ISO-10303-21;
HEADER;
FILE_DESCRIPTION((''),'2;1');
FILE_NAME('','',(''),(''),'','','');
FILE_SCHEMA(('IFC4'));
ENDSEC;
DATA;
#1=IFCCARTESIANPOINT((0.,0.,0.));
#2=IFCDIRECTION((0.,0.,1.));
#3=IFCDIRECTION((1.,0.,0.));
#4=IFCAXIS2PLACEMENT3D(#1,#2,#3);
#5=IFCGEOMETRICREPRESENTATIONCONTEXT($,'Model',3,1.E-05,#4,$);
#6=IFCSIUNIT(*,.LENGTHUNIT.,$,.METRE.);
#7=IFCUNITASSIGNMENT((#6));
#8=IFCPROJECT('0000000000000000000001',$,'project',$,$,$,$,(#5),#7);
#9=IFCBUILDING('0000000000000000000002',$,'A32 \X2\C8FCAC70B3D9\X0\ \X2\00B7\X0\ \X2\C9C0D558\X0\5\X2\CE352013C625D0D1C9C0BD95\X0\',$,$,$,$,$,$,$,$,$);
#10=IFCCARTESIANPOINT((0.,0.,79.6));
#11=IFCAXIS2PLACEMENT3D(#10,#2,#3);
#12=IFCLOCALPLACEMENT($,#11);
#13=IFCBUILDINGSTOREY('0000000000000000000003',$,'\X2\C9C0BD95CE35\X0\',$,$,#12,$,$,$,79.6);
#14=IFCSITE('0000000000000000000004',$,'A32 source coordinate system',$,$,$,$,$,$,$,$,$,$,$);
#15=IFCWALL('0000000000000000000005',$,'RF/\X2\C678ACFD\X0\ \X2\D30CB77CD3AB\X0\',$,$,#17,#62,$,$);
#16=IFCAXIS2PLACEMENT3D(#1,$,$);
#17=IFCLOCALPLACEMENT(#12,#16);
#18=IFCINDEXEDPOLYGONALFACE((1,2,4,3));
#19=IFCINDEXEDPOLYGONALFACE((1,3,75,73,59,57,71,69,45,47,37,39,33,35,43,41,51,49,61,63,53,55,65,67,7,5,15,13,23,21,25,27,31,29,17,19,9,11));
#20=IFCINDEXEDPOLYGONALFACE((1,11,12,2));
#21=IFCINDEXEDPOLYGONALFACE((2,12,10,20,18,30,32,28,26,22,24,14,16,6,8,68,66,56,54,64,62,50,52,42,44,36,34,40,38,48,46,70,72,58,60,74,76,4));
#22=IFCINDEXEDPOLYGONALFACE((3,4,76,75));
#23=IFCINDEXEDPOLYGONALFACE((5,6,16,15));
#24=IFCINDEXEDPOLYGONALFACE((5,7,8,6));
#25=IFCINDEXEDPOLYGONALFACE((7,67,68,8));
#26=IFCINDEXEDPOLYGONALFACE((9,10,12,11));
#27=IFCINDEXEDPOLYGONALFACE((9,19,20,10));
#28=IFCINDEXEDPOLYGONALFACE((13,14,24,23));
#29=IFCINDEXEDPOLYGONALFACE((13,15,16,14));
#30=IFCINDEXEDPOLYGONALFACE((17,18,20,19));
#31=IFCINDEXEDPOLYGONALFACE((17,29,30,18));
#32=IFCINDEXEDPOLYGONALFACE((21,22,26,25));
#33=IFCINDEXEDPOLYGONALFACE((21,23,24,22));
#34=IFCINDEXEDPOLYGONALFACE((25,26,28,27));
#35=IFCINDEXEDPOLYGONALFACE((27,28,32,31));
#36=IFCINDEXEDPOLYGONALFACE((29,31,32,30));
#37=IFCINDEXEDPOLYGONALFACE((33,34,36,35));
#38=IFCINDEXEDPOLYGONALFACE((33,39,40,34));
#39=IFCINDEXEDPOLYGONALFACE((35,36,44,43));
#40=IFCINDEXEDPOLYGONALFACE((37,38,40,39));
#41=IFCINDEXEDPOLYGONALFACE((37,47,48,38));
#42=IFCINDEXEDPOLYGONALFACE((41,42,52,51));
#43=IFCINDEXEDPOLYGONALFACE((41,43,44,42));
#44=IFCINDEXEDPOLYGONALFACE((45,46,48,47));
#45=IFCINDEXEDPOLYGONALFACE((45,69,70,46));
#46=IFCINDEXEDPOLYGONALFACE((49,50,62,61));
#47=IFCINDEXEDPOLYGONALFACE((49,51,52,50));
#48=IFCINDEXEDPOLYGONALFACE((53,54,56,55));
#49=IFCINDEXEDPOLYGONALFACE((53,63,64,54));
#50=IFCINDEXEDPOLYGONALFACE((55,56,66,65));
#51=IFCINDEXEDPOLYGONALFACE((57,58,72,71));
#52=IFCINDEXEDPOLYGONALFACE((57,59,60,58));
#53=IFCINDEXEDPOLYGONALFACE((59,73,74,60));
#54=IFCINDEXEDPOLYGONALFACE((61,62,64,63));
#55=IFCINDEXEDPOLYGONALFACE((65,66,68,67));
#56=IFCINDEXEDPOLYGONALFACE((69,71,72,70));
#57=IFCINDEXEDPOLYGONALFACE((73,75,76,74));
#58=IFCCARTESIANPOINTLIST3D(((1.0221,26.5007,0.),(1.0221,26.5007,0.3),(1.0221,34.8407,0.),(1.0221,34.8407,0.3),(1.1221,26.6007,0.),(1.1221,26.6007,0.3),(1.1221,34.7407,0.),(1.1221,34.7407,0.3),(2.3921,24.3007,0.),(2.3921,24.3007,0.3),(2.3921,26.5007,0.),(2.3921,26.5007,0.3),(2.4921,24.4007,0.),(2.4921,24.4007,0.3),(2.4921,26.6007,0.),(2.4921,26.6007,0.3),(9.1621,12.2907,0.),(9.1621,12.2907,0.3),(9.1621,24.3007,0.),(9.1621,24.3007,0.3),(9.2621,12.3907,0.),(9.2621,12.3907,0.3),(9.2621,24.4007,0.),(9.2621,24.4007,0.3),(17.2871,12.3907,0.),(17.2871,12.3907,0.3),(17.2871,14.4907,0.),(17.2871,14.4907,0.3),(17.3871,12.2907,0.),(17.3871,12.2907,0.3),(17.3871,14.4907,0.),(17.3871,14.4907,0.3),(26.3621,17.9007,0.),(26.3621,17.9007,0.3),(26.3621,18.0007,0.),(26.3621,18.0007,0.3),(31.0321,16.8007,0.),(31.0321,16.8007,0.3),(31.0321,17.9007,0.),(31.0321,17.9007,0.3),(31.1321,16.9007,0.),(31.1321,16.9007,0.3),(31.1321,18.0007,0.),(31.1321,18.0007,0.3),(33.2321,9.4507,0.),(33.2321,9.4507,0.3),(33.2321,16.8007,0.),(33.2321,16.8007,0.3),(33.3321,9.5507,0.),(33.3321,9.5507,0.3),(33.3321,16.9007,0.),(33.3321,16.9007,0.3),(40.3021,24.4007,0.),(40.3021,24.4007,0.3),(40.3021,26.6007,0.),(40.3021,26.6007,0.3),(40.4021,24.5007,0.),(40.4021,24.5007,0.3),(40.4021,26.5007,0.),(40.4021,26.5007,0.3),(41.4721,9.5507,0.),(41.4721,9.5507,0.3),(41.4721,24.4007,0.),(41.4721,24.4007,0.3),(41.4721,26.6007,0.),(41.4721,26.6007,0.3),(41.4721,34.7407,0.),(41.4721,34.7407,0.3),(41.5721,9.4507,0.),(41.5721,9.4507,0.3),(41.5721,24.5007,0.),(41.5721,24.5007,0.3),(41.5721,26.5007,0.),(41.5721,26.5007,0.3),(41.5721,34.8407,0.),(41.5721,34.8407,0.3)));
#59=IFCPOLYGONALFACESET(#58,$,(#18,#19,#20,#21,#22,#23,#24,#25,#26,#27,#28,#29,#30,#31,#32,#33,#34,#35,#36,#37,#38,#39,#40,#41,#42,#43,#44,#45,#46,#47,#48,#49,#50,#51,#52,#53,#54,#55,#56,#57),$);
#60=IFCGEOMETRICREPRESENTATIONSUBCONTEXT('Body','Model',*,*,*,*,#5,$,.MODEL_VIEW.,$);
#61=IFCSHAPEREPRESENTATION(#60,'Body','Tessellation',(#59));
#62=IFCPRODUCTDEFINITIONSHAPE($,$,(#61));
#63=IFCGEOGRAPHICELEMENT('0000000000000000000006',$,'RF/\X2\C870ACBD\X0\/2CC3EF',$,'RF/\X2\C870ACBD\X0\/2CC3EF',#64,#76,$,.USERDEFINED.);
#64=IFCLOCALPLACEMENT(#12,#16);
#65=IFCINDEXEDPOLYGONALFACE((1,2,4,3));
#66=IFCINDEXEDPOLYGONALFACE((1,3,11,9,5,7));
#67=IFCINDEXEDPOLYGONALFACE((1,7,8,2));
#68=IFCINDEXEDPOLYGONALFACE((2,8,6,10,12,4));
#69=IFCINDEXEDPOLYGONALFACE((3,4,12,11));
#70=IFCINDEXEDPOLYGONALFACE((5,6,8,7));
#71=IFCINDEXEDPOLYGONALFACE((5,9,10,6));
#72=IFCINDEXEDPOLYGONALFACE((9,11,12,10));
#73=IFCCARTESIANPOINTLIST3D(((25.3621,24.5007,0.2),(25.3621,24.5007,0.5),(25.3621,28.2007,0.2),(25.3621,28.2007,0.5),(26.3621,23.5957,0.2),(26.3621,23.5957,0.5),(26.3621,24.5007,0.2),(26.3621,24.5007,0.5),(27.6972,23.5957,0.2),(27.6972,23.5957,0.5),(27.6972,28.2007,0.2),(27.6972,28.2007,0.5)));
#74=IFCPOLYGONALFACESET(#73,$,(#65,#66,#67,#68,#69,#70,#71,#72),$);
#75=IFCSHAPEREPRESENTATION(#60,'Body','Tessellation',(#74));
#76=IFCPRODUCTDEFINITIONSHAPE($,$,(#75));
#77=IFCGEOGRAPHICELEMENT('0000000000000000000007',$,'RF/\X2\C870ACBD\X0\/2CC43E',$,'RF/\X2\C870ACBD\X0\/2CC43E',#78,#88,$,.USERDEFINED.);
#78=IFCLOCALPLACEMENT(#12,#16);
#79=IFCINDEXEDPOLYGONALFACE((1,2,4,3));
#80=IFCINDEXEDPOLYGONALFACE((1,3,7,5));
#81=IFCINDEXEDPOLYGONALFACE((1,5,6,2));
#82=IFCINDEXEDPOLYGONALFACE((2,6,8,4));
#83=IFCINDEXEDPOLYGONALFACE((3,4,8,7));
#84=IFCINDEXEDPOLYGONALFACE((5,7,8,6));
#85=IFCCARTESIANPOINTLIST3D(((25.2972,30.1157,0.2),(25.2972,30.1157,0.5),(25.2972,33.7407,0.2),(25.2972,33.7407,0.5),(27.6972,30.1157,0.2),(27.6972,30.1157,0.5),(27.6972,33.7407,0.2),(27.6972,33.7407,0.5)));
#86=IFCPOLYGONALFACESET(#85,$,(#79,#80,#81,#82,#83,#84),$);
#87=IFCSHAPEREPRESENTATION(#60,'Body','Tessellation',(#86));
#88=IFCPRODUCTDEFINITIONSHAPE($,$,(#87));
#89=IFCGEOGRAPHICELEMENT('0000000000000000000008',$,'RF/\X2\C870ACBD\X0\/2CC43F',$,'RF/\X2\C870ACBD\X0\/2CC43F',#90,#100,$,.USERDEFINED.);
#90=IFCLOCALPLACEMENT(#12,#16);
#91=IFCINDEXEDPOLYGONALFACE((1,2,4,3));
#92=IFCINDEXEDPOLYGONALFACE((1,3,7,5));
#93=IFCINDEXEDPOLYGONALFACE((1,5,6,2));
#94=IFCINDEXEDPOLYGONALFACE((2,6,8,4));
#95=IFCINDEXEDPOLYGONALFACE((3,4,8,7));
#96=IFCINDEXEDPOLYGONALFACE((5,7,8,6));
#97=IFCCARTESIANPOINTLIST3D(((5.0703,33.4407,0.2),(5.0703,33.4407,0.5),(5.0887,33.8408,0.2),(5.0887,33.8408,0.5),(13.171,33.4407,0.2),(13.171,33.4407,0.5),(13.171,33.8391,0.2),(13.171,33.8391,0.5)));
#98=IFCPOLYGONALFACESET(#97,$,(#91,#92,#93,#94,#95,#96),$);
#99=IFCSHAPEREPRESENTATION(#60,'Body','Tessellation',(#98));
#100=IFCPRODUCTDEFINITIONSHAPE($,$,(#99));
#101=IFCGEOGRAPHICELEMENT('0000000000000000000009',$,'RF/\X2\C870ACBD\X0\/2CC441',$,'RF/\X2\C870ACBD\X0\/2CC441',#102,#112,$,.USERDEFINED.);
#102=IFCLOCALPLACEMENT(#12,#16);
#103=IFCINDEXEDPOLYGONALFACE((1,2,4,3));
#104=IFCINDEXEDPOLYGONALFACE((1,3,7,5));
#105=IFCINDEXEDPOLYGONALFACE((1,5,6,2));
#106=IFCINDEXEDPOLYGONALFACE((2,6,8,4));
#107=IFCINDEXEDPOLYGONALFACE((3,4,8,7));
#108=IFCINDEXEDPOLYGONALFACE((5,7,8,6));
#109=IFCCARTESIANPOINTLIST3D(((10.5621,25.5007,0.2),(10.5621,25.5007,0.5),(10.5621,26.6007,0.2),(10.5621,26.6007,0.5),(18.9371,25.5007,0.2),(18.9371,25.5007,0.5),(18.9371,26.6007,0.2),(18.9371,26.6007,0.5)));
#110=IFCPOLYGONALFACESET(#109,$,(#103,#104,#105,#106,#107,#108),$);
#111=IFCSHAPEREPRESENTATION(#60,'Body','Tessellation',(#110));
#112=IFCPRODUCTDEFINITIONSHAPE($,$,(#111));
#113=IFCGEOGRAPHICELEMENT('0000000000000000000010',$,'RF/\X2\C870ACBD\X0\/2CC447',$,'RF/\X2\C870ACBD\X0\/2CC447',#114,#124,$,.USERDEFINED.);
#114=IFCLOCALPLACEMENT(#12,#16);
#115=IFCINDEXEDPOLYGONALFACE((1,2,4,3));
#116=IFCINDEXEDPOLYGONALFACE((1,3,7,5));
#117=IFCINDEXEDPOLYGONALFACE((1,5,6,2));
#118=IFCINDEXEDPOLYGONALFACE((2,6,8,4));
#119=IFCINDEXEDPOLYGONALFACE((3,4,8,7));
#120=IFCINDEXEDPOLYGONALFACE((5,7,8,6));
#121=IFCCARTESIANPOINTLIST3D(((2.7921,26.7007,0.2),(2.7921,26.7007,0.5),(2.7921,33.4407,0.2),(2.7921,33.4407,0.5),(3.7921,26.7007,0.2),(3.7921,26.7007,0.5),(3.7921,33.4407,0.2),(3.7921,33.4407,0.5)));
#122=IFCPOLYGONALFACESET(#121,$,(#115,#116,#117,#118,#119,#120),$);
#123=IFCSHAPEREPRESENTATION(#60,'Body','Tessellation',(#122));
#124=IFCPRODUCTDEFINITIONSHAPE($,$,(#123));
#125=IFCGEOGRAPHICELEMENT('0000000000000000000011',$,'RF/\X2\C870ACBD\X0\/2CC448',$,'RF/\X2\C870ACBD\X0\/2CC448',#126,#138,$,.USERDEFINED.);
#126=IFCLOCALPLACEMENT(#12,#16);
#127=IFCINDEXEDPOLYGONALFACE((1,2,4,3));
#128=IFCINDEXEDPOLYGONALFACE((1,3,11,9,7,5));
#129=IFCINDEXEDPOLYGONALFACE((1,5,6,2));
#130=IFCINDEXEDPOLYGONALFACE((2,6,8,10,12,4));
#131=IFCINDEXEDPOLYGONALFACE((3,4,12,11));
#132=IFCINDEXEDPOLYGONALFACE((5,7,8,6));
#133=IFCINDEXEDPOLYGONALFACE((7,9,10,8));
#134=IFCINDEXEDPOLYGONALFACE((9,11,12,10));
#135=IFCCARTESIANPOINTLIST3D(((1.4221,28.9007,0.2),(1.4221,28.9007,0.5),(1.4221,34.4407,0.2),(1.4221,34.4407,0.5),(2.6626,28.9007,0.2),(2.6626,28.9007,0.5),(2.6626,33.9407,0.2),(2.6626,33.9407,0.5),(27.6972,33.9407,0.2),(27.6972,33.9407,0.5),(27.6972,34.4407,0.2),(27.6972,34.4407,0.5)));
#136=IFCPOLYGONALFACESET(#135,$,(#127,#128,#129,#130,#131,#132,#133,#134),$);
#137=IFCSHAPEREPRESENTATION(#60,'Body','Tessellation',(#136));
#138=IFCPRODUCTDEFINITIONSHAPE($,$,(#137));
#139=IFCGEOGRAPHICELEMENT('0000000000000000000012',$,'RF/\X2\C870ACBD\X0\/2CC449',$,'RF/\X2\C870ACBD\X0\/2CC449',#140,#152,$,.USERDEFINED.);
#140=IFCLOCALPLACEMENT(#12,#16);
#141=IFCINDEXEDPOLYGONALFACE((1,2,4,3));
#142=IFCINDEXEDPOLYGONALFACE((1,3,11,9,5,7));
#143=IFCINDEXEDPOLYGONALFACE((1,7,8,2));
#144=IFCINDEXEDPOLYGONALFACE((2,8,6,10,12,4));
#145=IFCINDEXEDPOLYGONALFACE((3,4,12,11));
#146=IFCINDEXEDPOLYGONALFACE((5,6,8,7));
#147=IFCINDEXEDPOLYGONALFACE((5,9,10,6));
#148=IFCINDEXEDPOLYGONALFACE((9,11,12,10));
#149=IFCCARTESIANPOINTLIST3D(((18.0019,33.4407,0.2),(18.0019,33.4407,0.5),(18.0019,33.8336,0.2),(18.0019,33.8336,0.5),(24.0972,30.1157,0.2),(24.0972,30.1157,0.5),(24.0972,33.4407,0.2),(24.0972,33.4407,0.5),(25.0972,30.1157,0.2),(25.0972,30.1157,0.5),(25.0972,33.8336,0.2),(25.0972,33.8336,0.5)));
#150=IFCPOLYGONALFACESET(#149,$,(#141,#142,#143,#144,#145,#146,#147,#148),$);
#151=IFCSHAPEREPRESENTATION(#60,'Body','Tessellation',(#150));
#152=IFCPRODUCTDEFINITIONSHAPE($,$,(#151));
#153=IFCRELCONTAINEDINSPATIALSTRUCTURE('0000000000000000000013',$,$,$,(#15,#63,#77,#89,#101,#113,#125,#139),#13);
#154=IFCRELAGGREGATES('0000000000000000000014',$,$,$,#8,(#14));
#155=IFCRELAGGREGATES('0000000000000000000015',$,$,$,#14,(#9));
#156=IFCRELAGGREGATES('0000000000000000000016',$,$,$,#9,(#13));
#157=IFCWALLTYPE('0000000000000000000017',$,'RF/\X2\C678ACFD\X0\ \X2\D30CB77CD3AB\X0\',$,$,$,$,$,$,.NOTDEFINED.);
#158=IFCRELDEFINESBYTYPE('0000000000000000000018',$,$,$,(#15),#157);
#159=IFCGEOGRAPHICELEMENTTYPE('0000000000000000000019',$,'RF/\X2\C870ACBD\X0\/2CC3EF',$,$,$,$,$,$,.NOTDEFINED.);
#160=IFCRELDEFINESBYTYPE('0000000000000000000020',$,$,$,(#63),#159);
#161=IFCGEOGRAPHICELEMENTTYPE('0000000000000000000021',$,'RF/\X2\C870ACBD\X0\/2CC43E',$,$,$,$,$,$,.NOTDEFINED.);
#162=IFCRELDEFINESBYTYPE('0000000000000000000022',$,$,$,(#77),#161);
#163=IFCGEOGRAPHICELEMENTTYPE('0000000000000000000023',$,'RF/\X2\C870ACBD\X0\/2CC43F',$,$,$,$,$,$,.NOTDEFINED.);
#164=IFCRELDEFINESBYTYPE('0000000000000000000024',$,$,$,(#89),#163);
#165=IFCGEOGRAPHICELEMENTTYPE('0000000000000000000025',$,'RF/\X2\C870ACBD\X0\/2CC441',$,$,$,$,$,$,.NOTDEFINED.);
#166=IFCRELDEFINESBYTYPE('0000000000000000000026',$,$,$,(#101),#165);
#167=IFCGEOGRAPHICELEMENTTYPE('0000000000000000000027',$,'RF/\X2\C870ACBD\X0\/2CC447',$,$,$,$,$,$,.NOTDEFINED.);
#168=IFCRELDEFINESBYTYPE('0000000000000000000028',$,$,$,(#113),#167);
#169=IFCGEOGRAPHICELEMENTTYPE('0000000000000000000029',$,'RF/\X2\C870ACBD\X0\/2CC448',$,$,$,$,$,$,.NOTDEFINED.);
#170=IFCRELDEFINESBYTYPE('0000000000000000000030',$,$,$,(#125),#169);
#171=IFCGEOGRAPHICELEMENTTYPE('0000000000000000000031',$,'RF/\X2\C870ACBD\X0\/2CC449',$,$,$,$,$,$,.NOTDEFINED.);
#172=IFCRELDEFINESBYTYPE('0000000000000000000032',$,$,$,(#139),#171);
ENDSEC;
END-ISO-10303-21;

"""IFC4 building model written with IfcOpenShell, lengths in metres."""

from ifc_helpers import new_model, si_unit, frame, origin, origin_with_axes, place, context, subcontext, project, spatial, polyline, outline, extrude, source, transform, mapped, type_object, type_shapes, element, save


model = new_model("IFC4")

# Units and contexts
model_context = context("Model", 3, precision=1e-05, world=origin_with_axes())
body_context = subcontext(model_context, "Body", "Model", "MODEL_VIEW")
ifc_project = project(units=[si_unit("LENGTHUNIT", "METRE")], contexts=[model_context])

# Site, building, storey
site = spatial("IfcSite", under=ifc_project, Name="A32 source coordinate system")
building = spatial("IfcBuilding", under=site, Name="A32 주거동 · 지하5층–옥탑지붕")
storey_placement = place(None, frame((0.0, 0.0, 79.6), z_axis=(0.0, 0.0, 1.0), x_axis=(1.0, 0.0, 0.0)))
storey = spatial("IfcBuildingStorey", under=building, at=storey_placement, Name="지붕층", Elevation=79.6)

# Wall
wall_type_1 = type_object("IfcWallType", Name="RF/외곽 파라펫", PredefinedType="NOTDEFINED")
shared_shape_1 = source(origin(), body_context, "Body", "SweptSolid", [
    extrude(outline(polyline([(26.3621, 18.0007), (31.1321, 18.0007), (31.1321, 16.9007), (33.3321, 16.9007), (33.3321, 9.5507), (41.4721, 9.5507), (41.4721, 24.4007), (40.3021, 24.4007), (40.3021, 26.6007), (41.4721, 26.6007), (41.4721, 34.7407), (1.1221, 34.7407), (1.1221, 26.6007), (2.4921, 26.6007), (2.4921, 24.4007), (9.2621, 24.4007), (9.2621, 12.3907), (17.2871, 12.3907), (17.2871, 14.4907), (17.3871, 14.4907), (17.3871, 12.2907), (9.1621, 12.2907), (9.1621, 24.3007), (2.3921, 24.3007), (2.3921, 26.5007), (1.0221, 26.5007), (1.0221, 34.8407), (41.5721, 34.8407), (41.5721, 26.5007), (40.4021, 26.5007), (40.4021, 24.5007), (41.5721, 24.5007), (41.5721, 9.4507), (33.2321, 9.4507), (33.2321, 16.8007), (31.0321, 16.8007), (31.0321, 17.9007), (26.3621, 17.9007), (26.3621, 18.0007)])), origin(), (0.0, 0.0, 1.0), 0.3),
])
type_shapes(wall_type_1, [shared_shape_1])
wall_1_placement = place(storey_placement, origin_with_axes())
element("IfcWall", 1, at=wall_1_placement, inside=storey, type_object=wall_type_1, Name="RF/외곽 파라펫", context=body_context, shape_type="MappedRepresentation", body=[
    mapped(shared_shape_1, transform((0.0, 0.0, 0.0), scale=1.0)),
])

# Geographic elements
geographic_element_type_1 = type_object("IfcGeographicElementType", Name="RF/조경/2CC3EF", PredefinedType="NOTDEFINED")
shared_shape_2 = source(origin(), body_context, "Body", "SweptSolid", [
    extrude(outline(polyline([(26.3621, 23.5957), (26.3621, 24.5007), (25.3621, 24.5007), (25.3621, 28.2007), (27.6972, 28.2007), (27.6972, 23.5957), (26.3621, 23.5957)])), frame((0.0, 0.0, 0.2)), (0.0, 0.0, 1.0), 0.3),
])
type_shapes(geographic_element_type_1, [shared_shape_2])
geographic_element_1_placement = place(storey_placement, origin_with_axes())
element("IfcGeographicElement", 2, at=geographic_element_1_placement, inside=storey, type_object=geographic_element_type_1, Name="RF/조경/2CC3EF", ObjectType="RF/조경/2CC3EF", PredefinedType="USERDEFINED", context=body_context, shape_type="MappedRepresentation", body=[
    mapped(shared_shape_2, transform((0.0, 0.0, 0.0), scale=1.0)),
])
geographic_element_type_2 = type_object("IfcGeographicElementType", Name="RF/조경/2CC43E", PredefinedType="NOTDEFINED")
shared_shape_3 = source(origin(), body_context, "Body", "SweptSolid", [
    extrude(outline(polyline([(27.6972, 30.1157), (25.2972, 30.1157), (25.2972, 33.7407), (27.6972, 33.7407), (27.6972, 30.1157)])), frame((0.0, 0.0, 0.2)), (0.0, 0.0, 1.0), 0.3),
])
type_shapes(geographic_element_type_2, [shared_shape_3])
geographic_element_2_placement = place(storey_placement, origin_with_axes())
element("IfcGeographicElement", 3, at=geographic_element_2_placement, inside=storey, type_object=geographic_element_type_2, Name="RF/조경/2CC43E", ObjectType="RF/조경/2CC43E", PredefinedType="USERDEFINED", context=body_context, shape_type="MappedRepresentation", body=[
    mapped(shared_shape_3, transform((0.0, 0.0, 0.0), scale=1.0)),
])
geographic_element_type_3 = type_object("IfcGeographicElementType", Name="RF/조경/2CC43F", PredefinedType="NOTDEFINED")
shared_shape_4 = source(origin(), body_context, "Body", "SweptSolid", [
    extrude(outline(polyline([(13.171, 33.8391), (13.171, 33.4407), (5.0703, 33.4407), (5.0887, 33.8408), (13.171, 33.8391)])), frame((0.0, 0.0, 0.2)), (0.0, 0.0, 1.0), 0.3),
])
type_shapes(geographic_element_type_3, [shared_shape_4])
geographic_element_3_placement = place(storey_placement, origin_with_axes())
element("IfcGeographicElement", 4, at=geographic_element_3_placement, inside=storey, type_object=geographic_element_type_3, Name="RF/조경/2CC43F", ObjectType="RF/조경/2CC43F", PredefinedType="USERDEFINED", context=body_context, shape_type="MappedRepresentation", body=[
    mapped(shared_shape_4, transform((0.0, 0.0, 0.0), scale=1.0)),
])
geographic_element_type_4 = type_object("IfcGeographicElementType", Name="RF/조경/2CC441", PredefinedType="NOTDEFINED")
shared_shape_5 = source(origin(), body_context, "Body", "SweptSolid", [
    extrude(outline(polyline([(10.5621, 25.5007), (10.5621, 26.6007), (18.9371, 26.6007), (18.9371, 25.5007), (10.5621, 25.5007)])), frame((0.0, 0.0, 0.2)), (0.0, 0.0, 1.0), 0.3),
])
type_shapes(geographic_element_type_4, [shared_shape_5])
geographic_element_4_placement = place(storey_placement, origin_with_axes())
element("IfcGeographicElement", 5, at=geographic_element_4_placement, inside=storey, type_object=geographic_element_type_4, Name="RF/조경/2CC441", ObjectType="RF/조경/2CC441", PredefinedType="USERDEFINED", context=body_context, shape_type="MappedRepresentation", body=[
    mapped(shared_shape_5, transform((0.0, 0.0, 0.0), scale=1.0)),
])
geographic_element_type_5 = type_object("IfcGeographicElementType", Name="RF/조경/2CC447", PredefinedType="NOTDEFINED")
shared_shape_6 = source(origin(), body_context, "Body", "SweptSolid", [
    extrude(outline(polyline([(3.7921, 26.7007), (2.7921, 26.7007), (2.7921, 33.4407), (3.7921, 33.4407), (3.7921, 26.7007)])), frame((0.0, 0.0, 0.2)), (0.0, 0.0, 1.0), 0.3),
])
type_shapes(geographic_element_type_5, [shared_shape_6])
geographic_element_5_placement = place(storey_placement, origin_with_axes())
element("IfcGeographicElement", 6, at=geographic_element_5_placement, inside=storey, type_object=geographic_element_type_5, Name="RF/조경/2CC447", ObjectType="RF/조경/2CC447", PredefinedType="USERDEFINED", context=body_context, shape_type="MappedRepresentation", body=[
    mapped(shared_shape_6, transform((0.0, 0.0, 0.0), scale=1.0)),
])
geographic_element_type_6 = type_object("IfcGeographicElementType", Name="RF/조경/2CC448", PredefinedType="NOTDEFINED")
shared_shape_7 = source(origin(), body_context, "Body", "SweptSolid", [
    extrude(outline(polyline([(27.6972, 33.9407), (2.6626, 33.9407), (2.6626, 28.9007), (1.4221, 28.9007), (1.4221, 34.4407), (27.6972, 34.4407), (27.6972, 33.9407)])), frame((0.0, 0.0, 0.2)), (0.0, 0.0, 1.0), 0.3),
])
type_shapes(geographic_element_type_6, [shared_shape_7])
geographic_element_6_placement = place(storey_placement, origin_with_axes())
element("IfcGeographicElement", 7, at=geographic_element_6_placement, inside=storey, type_object=geographic_element_type_6, Name="RF/조경/2CC448", ObjectType="RF/조경/2CC448", PredefinedType="USERDEFINED", context=body_context, shape_type="MappedRepresentation", body=[
    mapped(shared_shape_7, transform((0.0, 0.0, 0.0), scale=1.0)),
])
geographic_element_type_7 = type_object("IfcGeographicElementType", Name="RF/조경/2CC449", PredefinedType="NOTDEFINED")
shared_shape_8 = source(origin(), body_context, "Body", "SweptSolid", [
    extrude(outline(polyline([(18.0019, 33.4407), (18.0019, 33.8336), (25.0972, 33.8336), (25.0972, 30.1157), (24.0972, 30.1157), (24.0972, 33.4407), (18.0019, 33.4407)])), frame((0.0, 0.0, 0.2)), (0.0, 0.0, 1.0), 0.3),
])
type_shapes(geographic_element_type_7, [shared_shape_8])
geographic_element_7_placement = place(storey_placement, origin_with_axes())
element("IfcGeographicElement", 8, at=geographic_element_7_placement, inside=storey, type_object=geographic_element_type_7, Name="RF/조경/2CC449", ObjectType="RF/조경/2CC449", PredefinedType="USERDEFINED", context=body_context, shape_type="MappedRepresentation", body=[
    mapped(shared_shape_8, transform((0.0, 0.0, 0.0), scale=1.0)),
])

save(model, "model.ifc")
